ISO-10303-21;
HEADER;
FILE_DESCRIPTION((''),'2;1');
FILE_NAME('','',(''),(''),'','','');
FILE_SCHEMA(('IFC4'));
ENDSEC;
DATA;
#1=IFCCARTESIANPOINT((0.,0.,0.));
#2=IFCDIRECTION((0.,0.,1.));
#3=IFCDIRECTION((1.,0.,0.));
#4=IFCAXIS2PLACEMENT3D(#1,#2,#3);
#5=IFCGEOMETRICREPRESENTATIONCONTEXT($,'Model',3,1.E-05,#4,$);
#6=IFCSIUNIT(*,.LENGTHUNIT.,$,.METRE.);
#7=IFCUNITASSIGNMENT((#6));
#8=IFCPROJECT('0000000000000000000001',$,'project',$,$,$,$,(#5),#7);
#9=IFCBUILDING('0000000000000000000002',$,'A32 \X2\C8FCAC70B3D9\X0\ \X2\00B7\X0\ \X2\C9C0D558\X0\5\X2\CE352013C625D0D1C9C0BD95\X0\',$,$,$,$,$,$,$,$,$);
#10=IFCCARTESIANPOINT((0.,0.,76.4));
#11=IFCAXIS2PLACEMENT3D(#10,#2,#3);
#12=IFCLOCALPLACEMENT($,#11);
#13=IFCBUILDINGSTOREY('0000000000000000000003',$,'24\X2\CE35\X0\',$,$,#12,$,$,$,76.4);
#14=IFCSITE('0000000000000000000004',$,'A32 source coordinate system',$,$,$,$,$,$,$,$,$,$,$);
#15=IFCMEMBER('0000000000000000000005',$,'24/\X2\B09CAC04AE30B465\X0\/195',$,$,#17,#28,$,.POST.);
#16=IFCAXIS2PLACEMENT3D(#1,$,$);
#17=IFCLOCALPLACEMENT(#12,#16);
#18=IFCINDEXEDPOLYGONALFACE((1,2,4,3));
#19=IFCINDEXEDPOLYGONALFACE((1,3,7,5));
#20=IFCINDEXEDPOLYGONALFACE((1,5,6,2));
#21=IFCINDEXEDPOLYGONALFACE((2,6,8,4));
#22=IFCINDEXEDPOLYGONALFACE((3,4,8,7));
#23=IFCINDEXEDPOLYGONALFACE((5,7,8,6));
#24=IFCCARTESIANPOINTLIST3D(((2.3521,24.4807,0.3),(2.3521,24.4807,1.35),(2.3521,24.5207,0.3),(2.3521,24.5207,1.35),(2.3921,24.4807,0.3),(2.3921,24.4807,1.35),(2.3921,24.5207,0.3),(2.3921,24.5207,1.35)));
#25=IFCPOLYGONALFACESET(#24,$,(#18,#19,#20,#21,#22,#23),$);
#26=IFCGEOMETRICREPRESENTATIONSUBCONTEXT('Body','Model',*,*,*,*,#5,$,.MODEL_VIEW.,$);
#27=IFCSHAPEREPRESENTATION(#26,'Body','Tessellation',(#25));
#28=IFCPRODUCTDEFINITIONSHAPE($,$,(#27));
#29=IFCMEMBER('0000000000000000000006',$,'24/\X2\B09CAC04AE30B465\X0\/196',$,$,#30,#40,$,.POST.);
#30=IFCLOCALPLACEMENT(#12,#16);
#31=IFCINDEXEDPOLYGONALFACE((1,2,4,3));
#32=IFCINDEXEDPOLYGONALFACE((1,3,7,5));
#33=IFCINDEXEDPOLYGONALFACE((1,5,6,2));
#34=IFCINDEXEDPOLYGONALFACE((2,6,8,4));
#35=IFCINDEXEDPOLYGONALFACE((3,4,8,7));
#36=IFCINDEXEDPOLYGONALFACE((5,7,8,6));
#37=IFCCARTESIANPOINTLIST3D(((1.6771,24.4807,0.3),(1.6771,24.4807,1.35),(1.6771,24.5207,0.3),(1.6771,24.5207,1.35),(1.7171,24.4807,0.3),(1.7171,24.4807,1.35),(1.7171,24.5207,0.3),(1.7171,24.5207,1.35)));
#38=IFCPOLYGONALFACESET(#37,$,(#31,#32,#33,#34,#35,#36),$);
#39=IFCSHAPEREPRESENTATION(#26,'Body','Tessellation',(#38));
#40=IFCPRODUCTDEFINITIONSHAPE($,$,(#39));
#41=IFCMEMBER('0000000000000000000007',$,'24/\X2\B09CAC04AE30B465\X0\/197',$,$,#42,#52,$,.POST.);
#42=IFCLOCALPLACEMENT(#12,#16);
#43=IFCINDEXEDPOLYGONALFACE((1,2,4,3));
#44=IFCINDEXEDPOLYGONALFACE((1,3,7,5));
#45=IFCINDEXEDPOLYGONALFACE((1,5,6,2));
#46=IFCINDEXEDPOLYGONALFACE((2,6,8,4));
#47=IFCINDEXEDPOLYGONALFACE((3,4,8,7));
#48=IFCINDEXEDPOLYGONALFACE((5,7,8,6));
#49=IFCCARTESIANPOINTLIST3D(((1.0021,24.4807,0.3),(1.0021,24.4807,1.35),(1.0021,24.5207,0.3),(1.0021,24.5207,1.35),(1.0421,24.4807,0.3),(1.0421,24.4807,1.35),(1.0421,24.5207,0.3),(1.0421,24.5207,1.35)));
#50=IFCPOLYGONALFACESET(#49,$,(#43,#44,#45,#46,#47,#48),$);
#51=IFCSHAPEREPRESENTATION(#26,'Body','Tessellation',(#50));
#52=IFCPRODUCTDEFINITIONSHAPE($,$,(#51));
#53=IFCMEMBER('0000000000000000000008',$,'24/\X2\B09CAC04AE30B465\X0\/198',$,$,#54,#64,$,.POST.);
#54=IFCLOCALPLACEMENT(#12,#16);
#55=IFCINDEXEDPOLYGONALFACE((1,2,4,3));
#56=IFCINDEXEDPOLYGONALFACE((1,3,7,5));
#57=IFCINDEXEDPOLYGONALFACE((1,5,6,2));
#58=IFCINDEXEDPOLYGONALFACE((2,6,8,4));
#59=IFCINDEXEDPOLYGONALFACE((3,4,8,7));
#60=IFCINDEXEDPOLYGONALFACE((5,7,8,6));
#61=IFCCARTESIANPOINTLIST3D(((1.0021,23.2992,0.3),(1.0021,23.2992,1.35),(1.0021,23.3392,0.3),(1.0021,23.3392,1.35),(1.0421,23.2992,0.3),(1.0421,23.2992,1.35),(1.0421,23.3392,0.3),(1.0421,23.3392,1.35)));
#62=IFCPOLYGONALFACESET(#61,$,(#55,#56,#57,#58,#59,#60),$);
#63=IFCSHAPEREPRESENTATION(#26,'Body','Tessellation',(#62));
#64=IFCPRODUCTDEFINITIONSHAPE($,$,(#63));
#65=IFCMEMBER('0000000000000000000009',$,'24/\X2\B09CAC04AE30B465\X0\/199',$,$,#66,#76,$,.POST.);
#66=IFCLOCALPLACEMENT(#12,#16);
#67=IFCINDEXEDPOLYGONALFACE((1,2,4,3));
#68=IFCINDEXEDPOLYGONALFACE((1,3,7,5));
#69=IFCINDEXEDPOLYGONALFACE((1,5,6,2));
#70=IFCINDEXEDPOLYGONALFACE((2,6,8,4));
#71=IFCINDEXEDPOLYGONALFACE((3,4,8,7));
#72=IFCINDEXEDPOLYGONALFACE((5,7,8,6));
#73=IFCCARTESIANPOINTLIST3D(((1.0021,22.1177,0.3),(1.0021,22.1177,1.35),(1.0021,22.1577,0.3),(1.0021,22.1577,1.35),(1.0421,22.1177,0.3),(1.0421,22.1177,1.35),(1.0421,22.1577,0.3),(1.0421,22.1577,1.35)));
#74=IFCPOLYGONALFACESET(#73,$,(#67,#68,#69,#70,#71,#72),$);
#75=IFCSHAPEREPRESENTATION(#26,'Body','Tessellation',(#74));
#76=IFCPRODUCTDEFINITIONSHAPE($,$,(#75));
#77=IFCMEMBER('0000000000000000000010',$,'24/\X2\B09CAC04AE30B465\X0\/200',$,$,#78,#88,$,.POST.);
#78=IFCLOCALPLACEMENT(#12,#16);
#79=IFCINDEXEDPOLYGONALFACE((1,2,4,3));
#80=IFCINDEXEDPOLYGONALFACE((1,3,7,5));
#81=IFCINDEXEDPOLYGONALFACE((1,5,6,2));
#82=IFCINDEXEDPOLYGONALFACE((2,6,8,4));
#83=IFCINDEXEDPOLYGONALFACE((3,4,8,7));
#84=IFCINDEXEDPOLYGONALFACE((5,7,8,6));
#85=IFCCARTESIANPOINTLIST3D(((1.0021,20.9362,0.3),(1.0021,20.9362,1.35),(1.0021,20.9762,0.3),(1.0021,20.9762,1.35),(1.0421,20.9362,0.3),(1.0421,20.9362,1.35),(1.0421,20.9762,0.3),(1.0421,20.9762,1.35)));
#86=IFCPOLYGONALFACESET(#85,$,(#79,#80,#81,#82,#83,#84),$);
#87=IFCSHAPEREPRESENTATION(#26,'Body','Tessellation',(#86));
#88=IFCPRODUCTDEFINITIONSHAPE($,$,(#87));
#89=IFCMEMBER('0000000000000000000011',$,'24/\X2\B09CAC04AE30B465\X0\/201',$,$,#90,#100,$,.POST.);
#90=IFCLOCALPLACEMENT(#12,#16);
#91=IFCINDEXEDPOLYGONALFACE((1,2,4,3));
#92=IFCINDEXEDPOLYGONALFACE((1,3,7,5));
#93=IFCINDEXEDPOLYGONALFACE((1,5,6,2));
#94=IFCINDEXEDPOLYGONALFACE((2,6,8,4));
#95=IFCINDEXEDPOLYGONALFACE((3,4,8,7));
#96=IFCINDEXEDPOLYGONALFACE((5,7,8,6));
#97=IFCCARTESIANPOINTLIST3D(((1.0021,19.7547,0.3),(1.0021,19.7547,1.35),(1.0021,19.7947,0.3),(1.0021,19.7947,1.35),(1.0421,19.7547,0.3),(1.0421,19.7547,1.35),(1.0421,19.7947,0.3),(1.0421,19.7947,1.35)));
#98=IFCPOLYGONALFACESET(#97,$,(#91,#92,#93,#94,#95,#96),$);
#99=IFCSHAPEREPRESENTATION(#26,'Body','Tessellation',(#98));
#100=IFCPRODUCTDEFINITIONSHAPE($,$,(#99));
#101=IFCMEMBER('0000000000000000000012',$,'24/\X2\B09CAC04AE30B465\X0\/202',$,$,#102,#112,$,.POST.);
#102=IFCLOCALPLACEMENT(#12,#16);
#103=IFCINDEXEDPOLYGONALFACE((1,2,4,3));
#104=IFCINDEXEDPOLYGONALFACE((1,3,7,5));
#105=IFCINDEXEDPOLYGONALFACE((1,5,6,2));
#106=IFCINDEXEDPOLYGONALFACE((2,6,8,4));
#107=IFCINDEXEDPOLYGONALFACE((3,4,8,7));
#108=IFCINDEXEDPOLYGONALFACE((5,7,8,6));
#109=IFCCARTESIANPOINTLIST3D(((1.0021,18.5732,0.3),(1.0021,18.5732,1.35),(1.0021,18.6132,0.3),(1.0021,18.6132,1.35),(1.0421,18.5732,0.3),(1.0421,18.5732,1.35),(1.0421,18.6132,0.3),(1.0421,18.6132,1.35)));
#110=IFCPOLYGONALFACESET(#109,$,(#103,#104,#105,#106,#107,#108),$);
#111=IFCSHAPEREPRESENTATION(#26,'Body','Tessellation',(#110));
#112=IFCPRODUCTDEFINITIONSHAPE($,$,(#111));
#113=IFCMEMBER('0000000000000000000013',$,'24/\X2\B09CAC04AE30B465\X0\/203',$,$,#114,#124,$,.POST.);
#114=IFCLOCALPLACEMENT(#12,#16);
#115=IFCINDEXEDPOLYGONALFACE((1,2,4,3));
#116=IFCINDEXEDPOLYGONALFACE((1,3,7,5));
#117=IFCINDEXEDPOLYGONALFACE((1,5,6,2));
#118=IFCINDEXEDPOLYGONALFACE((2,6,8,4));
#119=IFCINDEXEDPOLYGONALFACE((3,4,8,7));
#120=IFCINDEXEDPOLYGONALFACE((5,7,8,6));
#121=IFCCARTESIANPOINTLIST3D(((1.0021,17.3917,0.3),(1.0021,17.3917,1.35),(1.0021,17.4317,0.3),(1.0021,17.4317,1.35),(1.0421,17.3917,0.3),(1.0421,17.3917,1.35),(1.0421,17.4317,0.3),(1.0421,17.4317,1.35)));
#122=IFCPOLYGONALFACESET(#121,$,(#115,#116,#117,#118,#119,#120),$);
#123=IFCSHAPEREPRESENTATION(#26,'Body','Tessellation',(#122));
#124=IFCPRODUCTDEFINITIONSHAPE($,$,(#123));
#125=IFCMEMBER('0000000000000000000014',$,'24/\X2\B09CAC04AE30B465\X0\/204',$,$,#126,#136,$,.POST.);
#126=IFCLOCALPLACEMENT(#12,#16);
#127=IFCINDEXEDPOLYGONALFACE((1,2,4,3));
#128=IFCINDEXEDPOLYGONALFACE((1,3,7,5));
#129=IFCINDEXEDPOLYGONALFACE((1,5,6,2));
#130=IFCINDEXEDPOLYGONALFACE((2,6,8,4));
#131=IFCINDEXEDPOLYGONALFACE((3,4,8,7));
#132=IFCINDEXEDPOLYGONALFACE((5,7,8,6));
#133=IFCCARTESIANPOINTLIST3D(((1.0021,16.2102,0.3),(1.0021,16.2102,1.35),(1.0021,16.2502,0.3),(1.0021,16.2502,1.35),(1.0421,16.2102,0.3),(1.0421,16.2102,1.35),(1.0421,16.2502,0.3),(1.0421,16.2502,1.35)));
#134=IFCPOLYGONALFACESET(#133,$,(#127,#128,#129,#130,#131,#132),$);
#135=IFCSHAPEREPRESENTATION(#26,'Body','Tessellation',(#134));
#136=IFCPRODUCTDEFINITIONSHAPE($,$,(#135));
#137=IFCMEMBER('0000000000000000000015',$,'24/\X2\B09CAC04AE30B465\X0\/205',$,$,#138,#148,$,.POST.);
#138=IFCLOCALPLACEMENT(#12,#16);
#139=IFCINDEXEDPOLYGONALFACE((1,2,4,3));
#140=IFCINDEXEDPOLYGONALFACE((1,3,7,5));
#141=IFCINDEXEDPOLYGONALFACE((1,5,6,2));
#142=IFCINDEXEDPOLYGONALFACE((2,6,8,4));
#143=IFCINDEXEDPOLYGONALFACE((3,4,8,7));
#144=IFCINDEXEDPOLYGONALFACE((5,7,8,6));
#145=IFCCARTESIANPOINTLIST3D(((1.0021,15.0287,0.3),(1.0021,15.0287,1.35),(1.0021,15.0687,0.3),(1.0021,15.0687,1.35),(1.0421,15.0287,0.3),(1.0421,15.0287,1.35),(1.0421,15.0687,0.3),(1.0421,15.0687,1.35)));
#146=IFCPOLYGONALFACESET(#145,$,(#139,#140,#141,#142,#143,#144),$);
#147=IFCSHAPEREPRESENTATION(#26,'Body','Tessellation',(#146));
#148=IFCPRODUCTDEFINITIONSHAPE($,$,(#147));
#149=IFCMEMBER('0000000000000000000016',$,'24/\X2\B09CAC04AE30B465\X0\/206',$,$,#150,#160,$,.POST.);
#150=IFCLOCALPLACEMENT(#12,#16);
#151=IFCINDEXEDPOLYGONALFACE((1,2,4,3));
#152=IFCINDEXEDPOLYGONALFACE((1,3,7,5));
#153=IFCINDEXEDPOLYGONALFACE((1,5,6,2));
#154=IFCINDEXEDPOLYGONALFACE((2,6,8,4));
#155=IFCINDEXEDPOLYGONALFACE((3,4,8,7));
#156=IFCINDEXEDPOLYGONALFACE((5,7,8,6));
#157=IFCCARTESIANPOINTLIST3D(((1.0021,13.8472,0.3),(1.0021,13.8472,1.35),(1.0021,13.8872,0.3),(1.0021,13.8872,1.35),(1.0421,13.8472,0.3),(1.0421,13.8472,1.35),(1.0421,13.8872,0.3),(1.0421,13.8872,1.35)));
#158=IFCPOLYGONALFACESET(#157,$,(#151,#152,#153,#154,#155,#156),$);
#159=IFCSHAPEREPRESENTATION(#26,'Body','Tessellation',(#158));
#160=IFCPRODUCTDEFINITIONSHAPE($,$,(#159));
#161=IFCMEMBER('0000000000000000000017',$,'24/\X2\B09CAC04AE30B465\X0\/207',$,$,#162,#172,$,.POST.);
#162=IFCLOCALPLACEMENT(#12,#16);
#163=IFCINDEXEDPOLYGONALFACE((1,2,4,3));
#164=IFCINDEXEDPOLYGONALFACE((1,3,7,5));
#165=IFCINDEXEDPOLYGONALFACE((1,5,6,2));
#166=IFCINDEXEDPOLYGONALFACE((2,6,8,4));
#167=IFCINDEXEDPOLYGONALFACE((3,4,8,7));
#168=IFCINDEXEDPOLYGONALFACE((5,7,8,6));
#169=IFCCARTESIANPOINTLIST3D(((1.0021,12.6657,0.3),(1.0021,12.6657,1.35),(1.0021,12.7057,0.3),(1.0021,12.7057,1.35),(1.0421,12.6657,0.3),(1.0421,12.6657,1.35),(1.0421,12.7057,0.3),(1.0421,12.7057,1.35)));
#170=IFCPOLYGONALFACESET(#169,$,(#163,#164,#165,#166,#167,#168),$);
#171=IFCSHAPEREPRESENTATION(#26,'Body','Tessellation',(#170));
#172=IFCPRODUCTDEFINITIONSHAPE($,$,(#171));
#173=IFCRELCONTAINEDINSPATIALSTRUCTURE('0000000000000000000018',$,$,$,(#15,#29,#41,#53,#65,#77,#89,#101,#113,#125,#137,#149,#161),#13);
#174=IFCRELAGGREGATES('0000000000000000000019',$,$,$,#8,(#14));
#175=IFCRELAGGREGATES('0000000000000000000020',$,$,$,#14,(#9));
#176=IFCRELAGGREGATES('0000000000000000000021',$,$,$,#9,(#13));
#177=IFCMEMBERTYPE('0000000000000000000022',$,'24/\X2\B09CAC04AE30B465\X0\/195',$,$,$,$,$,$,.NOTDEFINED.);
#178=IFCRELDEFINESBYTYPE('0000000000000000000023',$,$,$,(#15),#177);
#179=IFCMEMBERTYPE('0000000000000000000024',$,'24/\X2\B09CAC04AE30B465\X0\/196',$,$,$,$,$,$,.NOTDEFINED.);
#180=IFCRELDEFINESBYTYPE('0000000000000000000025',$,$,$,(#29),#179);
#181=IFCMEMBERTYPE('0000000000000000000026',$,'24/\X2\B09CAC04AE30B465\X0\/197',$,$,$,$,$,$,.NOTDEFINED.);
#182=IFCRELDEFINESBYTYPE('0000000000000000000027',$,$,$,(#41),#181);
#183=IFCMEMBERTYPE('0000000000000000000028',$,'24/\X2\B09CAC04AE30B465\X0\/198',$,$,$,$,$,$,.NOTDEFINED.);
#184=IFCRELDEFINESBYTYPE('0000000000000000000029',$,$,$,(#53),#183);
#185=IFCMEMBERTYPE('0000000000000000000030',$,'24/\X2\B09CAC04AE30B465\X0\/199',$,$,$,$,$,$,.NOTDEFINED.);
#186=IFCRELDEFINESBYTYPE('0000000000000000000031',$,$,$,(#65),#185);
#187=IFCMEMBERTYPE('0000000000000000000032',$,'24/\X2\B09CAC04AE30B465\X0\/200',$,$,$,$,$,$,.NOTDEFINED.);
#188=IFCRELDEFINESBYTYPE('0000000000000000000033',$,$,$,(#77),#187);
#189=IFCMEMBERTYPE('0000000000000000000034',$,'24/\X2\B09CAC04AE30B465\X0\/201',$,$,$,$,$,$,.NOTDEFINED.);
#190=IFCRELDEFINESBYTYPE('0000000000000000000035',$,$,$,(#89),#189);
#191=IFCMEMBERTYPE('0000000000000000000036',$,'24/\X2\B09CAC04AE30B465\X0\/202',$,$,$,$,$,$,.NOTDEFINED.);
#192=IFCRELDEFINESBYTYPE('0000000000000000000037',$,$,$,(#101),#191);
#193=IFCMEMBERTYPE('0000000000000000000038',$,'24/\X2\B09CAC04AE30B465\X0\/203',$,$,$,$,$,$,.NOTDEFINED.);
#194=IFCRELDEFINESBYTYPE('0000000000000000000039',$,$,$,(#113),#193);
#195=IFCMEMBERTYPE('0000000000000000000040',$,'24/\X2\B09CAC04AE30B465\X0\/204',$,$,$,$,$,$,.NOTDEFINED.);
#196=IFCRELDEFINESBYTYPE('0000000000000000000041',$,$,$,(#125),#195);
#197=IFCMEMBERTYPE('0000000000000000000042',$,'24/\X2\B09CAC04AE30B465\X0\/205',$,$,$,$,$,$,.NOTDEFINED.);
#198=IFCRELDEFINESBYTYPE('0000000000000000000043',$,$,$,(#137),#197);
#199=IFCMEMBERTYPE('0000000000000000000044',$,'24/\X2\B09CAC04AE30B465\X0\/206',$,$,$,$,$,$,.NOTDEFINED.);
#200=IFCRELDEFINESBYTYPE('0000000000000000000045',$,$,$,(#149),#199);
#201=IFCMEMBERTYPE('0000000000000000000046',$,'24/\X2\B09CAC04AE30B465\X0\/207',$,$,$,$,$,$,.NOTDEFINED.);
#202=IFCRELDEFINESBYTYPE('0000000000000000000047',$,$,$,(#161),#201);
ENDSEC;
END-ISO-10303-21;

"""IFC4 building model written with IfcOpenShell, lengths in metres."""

from ifc_helpers import new_model, si_unit, frame, origin, origin_with_axes, place, context, subcontext, project, spatial, polyline, outline, extrude, source, transform, mapped, type_object, type_shapes, element, save


model = new_model("IFC4")

# Units and contexts
model_context = context("Model", 3, precision=1e-05, world=origin_with_axes())
body_context = subcontext(model_context, "Body", "Model", "MODEL_VIEW")
ifc_project = project(units=[si_unit("LENGTHUNIT", "METRE")], contexts=[model_context])

# Site, building, storey
site = spatial("IfcSite", under=ifc_project, Name="A32 source coordinate system")
building = spatial("IfcBuilding", under=site, Name="A32 주거동 · 지하5층–옥탑지붕")
storey_placement = place(None, frame((0.0, 0.0, 76.4), z_axis=(0.0, 0.0, 1.0), x_axis=(1.0, 0.0, 0.0)))
storey = spatial("IfcBuildingStorey", under=building, at=storey_placement, Name="24층", Elevation=76.4)

# Members
member_type_1 = type_object("IfcMemberType", Name="24/난간기둥/195", PredefinedType="NOTDEFINED")
shared_shape_1 = source(origin(), body_context, "Body", "SweptSolid", [
    extrude(outline(polyline([(2.3921, 24.4807), (2.3521, 24.4807), (2.3521, 24.5207), (2.3921, 24.5207), (2.3921, 24.4807)])), frame((0.0, 0.0, 0.3)), (0.0, 0.0, 1.0), 1.05),
])
type_shapes(member_type_1, [shared_shape_1])
member_1_placement = place(storey_placement, origin_with_axes())
element("IfcMember", 1, at=member_1_placement, inside=storey, type_object=member_type_1, Name="24/난간기둥/195", PredefinedType="POST", context=body_context, shape_type="MappedRepresentation", body=[
    mapped(shared_shape_1, transform((0.0, 0.0, 0.0), scale=1.0)),
])
member_type_2 = type_object("IfcMemberType", Name="24/난간기둥/196", PredefinedType="NOTDEFINED")
shared_shape_2 = source(origin(), body_context, "Body", "SweptSolid", [
    extrude(outline(polyline([(1.7171, 24.4807), (1.6771, 24.4807), (1.6771, 24.5207), (1.7171, 24.5207), (1.7171, 24.4807)])), frame((0.0, 0.0, 0.3)), (0.0, 0.0, 1.0), 1.05),
])
type_shapes(member_type_2, [shared_shape_2])
member_2_placement = place(storey_placement, origin_with_axes())
element("IfcMember", 2, at=member_2_placement, inside=storey, type_object=member_type_2, Name="24/난간기둥/196", PredefinedType="POST", context=body_context, shape_type="MappedRepresentation", body=[
    mapped(shared_shape_2, transform((0.0, 0.0, 0.0), scale=1.0)),
])
member_type_3 = type_object("IfcMemberType", Name="24/난간기둥/197", PredefinedType="NOTDEFINED")
shared_shape_3 = source(origin(), body_context, "Body", "SweptSolid", [
    extrude(outline(polyline([(1.0421, 24.4807), (1.0021, 24.4807), (1.0021, 24.5207), (1.0421, 24.5207), (1.0421, 24.4807)])), frame((0.0, 0.0, 0.3)), (0.0, 0.0, 1.0), 1.05),
])
type_shapes(member_type_3, [shared_shape_3])
member_3_placement = place(storey_placement, origin_with_axes())
element("IfcMember", 3, at=member_3_placement, inside=storey, type_object=member_type_3, Name="24/난간기둥/197", PredefinedType="POST", context=body_context, shape_type="MappedRepresentation", body=[
    mapped(shared_shape_3, transform((0.0, 0.0, 0.0), scale=1.0)),
])
member_type_4 = type_object("IfcMemberType", Name="24/난간기둥/198", PredefinedType="NOTDEFINED")
shared_shape_4 = source(origin(), body_context, "Body", "SweptSolid", [
    extrude(outline(polyline([(1.0421, 23.2992), (1.0021, 23.2992), (1.0021, 23.3392), (1.0421, 23.3392), (1.0421, 23.2992)])), frame((0.0, 0.0, 0.3)), (0.0, 0.0, 1.0), 1.05),
])
type_shapes(member_type_4, [shared_shape_4])
member_4_placement = place(storey_placement, origin_with_axes())
element("IfcMember", 4, at=member_4_placement, inside=storey, type_object=member_type_4, Name="24/난간기둥/198", PredefinedType="POST", context=body_context, shape_type="MappedRepresentation", body=[
    mapped(shared_shape_4, transform((0.0, 0.0, 0.0), scale=1.0)),
])
member_type_5 = type_object("IfcMemberType", Name="24/난간기둥/199", PredefinedType="NOTDEFINED")
shared_shape_5 = source(origin(), body_context, "Body", "SweptSolid", [
    extrude(outline(polyline([(1.0421, 22.1177), (1.0021, 22.1177), (1.0021, 22.1577), (1.0421, 22.1577), (1.0421, 22.1177)])), frame((0.0, 0.0, 0.3)), (0.0, 0.0, 1.0), 1.05),
])
type_shapes(member_type_5, [shared_shape_5])
member_5_placement = place(storey_placement, origin_with_axes())
element("IfcMember", 5, at=member_5_placement, inside=storey, type_object=member_type_5, Name="24/난간기둥/199", PredefinedType="POST", context=body_context, shape_type="MappedRepresentation", body=[
    mapped(shared_shape_5, transform((0.0, 0.0, 0.0), scale=1.0)),
])
member_type_6 = type_object("IfcMemberType", Name="24/난간기둥/200", PredefinedType="NOTDEFINED")
shared_shape_6 = source(origin(), body_context, "Body", "SweptSolid", [
    extrude(outline(polyline([(1.0421, 20.9362), (1.0021, 20.9362), (1.0021, 20.9762), (1.0421, 20.9762), (1.0421, 20.9362)])), frame((0.0, 0.0, 0.3)), (0.0, 0.0, 1.0), 1.05),
])
type_shapes(member_type_6, [shared_shape_6])
member_6_placement = place(storey_placement, origin_with_axes())
element("IfcMember", 6, at=member_6_placement, inside=storey, type_object=member_type_6, Name="24/난간기둥/200", PredefinedType="POST", context=body_context, shape_type="MappedRepresentation", body=[
    mapped(shared_shape_6, transform((0.0, 0.0, 0.0), scale=1.0)),
])
member_type_7 = type_object("IfcMemberType", Name="24/난간기둥/201", PredefinedType="NOTDEFINED")
shared_shape_7 = source(origin(), body_context, "Body", "SweptSolid", [
    extrude(outline(polyline([(1.0421, 19.7547), (1.0021, 19.7547), (1.0021, 19.7947), (1.0421, 19.7947), (1.0421, 19.7547)])), frame((0.0, 0.0, 0.3)), (0.0, 0.0, 1.0), 1.05),
])
type_shapes(member_type_7, [shared_shape_7])
member_7_placement = place(storey_placement, origin_with_axes())
element("IfcMember", 7, at=member_7_placement, inside=storey, type_object=member_type_7, Name="24/난간기둥/201", PredefinedType="POST", context=body_context, shape_type="MappedRepresentation", body=[
    mapped(shared_shape_7, transform((0.0, 0.0, 0.0), scale=1.0)),
])
member_type_8 = type_object("IfcMemberType", Name="24/난간기둥/202", PredefinedType="NOTDEFINED")
shared_shape_8 = source(origin(), body_context, "Body", "SweptSolid", [
    extrude(outline(polyline([(1.0421, 18.5732), (1.0021, 18.5732), (1.0021, 18.6132), (1.0421, 18.6132), (1.0421, 18.5732)])), frame((0.0, 0.0, 0.3)), (0.0, 0.0, 1.0), 1.05),
])
type_shapes(member_type_8, [shared_shape_8])
member_8_placement = place(storey_placement, origin_with_axes())
element("IfcMember", 8, at=member_8_placement, inside=storey, type_object=member_type_8, Name="24/난간기둥/202", PredefinedType="POST", context=body_context, shape_type="MappedRepresentation", body=[
    mapped(shared_shape_8, transform((0.0, 0.0, 0.0), scale=1.0)),
])
member_type_9 = type_object("IfcMemberType", Name="24/난간기둥/203", PredefinedType="NOTDEFINED")
shared_shape_9 = source(origin(), body_context, "Body", "SweptSolid", [
    extrude(outline(polyline([(1.0421, 17.3917), (1.0021, 17.3917), (1.0021, 17.4317), (1.0421, 17.4317), (1.0421, 17.3917)])), frame((0.0, 0.0, 0.3)), (0.0, 0.0, 1.0), 1.05),
])
type_shapes(member_type_9, [shared_shape_9])
member_9_placement = place(storey_placement, origin_with_axes())
element("IfcMember", 9, at=member_9_placement, inside=storey, type_object=member_type_9, Name="24/난간기둥/203", PredefinedType="POST", context=body_context, shape_type="MappedRepresentation", body=[
    mapped(shared_shape_9, transform((0.0, 0.0, 0.0), scale=1.0)),
])
member_type_10 = type_object("IfcMemberType", Name="24/난간기둥/204", PredefinedType="NOTDEFINED")
shared_shape_10 = source(origin(), body_context, "Body", "SweptSolid", [
    extrude(outline(polyline([(1.0421, 16.2102), (1.0021, 16.2102), (1.0021, 16.2502), (1.0421, 16.2502), (1.0421, 16.2102)])), frame((0.0, 0.0, 0.3)), (0.0, 0.0, 1.0), 1.05),
])
type_shapes(member_type_10, [shared_shape_10])
member_10_placement = place(storey_placement, origin_with_axes())
element("IfcMember", 10, at=member_10_placement, inside=storey, type_object=member_type_10, Name="24/난간기둥/204", PredefinedType="POST", context=body_context, shape_type="MappedRepresentation", body=[
    mapped(shared_shape_10, transform((0.0, 0.0, 0.0), scale=1.0)),
])
member_type_11 = type_object("IfcMemberType", Name="24/난간기둥/205", PredefinedType="NOTDEFINED")
shared_shape_11 = source(origin(), body_context, "Body", "SweptSolid", [
    extrude(outline(polyline([(1.0421, 15.0287), (1.0021, 15.0287), (1.0021, 15.0687), (1.0421, 15.0687), (1.0421, 15.0287)])), frame((0.0, 0.0, 0.3)), (0.0, 0.0, 1.0), 1.05),
])
type_shapes(member_type_11, [shared_shape_11])
member_11_placement = place(storey_placement, origin_with_axes())
element("IfcMember", 11, at=member_11_placement, inside=storey, type_object=member_type_11, Name="24/난간기둥/205", PredefinedType="POST", context=body_context, shape_type="MappedRepresentation", body=[
    mapped(shared_shape_11, transform((0.0, 0.0, 0.0), scale=1.0)),
])
member_type_12 = type_object("IfcMemberType", Name="24/난간기둥/206", PredefinedType="NOTDEFINED")
shared_shape_12 = source(origin(), body_context, "Body", "SweptSolid", [
    extrude(outline(polyline([(1.0421, 13.8472), (1.0021, 13.8472), (1.0021, 13.8872), (1.0421, 13.8872), (1.0421, 13.8472)])), frame((0.0, 0.0, 0.3)), (0.0, 0.0, 1.0), 1.05),
])
type_shapes(member_type_12, [shared_shape_12])
member_12_placement = place(storey_placement, origin_with_axes())
element("IfcMember", 12, at=member_12_placement, inside=storey, type_object=member_type_12, Name="24/난간기둥/206", PredefinedType="POST", context=body_context, shape_type="MappedRepresentation", body=[
    mapped(shared_shape_12, transform((0.0, 0.0, 0.0), scale=1.0)),
])
member_type_13 = type_object("IfcMemberType", Name="24/난간기둥/207", PredefinedType="NOTDEFINED")
shared_shape_13 = source(origin(), body_context, "Body", "SweptSolid", [
    extrude(outline(polyline([(1.0421, 12.6657), (1.0021, 12.6657), (1.0021, 12.7057), (1.0421, 12.7057), (1.0421, 12.6657)])), frame((0.0, 0.0, 0.3)), (0.0, 0.0, 1.0), 1.05),
])
type_shapes(member_type_13, [shared_shape_13])
member_13_placement = place(storey_placement, origin_with_axes())
element("IfcMember", 13, at=member_13_placement, inside=storey, type_object=member_type_13, Name="24/난간기둥/207", PredefinedType="POST", context=body_context, shape_type="MappedRepresentation", body=[
    mapped(shared_shape_13, transform((0.0, 0.0, 0.0), scale=1.0)),
])

save(model, "model.ifc")
